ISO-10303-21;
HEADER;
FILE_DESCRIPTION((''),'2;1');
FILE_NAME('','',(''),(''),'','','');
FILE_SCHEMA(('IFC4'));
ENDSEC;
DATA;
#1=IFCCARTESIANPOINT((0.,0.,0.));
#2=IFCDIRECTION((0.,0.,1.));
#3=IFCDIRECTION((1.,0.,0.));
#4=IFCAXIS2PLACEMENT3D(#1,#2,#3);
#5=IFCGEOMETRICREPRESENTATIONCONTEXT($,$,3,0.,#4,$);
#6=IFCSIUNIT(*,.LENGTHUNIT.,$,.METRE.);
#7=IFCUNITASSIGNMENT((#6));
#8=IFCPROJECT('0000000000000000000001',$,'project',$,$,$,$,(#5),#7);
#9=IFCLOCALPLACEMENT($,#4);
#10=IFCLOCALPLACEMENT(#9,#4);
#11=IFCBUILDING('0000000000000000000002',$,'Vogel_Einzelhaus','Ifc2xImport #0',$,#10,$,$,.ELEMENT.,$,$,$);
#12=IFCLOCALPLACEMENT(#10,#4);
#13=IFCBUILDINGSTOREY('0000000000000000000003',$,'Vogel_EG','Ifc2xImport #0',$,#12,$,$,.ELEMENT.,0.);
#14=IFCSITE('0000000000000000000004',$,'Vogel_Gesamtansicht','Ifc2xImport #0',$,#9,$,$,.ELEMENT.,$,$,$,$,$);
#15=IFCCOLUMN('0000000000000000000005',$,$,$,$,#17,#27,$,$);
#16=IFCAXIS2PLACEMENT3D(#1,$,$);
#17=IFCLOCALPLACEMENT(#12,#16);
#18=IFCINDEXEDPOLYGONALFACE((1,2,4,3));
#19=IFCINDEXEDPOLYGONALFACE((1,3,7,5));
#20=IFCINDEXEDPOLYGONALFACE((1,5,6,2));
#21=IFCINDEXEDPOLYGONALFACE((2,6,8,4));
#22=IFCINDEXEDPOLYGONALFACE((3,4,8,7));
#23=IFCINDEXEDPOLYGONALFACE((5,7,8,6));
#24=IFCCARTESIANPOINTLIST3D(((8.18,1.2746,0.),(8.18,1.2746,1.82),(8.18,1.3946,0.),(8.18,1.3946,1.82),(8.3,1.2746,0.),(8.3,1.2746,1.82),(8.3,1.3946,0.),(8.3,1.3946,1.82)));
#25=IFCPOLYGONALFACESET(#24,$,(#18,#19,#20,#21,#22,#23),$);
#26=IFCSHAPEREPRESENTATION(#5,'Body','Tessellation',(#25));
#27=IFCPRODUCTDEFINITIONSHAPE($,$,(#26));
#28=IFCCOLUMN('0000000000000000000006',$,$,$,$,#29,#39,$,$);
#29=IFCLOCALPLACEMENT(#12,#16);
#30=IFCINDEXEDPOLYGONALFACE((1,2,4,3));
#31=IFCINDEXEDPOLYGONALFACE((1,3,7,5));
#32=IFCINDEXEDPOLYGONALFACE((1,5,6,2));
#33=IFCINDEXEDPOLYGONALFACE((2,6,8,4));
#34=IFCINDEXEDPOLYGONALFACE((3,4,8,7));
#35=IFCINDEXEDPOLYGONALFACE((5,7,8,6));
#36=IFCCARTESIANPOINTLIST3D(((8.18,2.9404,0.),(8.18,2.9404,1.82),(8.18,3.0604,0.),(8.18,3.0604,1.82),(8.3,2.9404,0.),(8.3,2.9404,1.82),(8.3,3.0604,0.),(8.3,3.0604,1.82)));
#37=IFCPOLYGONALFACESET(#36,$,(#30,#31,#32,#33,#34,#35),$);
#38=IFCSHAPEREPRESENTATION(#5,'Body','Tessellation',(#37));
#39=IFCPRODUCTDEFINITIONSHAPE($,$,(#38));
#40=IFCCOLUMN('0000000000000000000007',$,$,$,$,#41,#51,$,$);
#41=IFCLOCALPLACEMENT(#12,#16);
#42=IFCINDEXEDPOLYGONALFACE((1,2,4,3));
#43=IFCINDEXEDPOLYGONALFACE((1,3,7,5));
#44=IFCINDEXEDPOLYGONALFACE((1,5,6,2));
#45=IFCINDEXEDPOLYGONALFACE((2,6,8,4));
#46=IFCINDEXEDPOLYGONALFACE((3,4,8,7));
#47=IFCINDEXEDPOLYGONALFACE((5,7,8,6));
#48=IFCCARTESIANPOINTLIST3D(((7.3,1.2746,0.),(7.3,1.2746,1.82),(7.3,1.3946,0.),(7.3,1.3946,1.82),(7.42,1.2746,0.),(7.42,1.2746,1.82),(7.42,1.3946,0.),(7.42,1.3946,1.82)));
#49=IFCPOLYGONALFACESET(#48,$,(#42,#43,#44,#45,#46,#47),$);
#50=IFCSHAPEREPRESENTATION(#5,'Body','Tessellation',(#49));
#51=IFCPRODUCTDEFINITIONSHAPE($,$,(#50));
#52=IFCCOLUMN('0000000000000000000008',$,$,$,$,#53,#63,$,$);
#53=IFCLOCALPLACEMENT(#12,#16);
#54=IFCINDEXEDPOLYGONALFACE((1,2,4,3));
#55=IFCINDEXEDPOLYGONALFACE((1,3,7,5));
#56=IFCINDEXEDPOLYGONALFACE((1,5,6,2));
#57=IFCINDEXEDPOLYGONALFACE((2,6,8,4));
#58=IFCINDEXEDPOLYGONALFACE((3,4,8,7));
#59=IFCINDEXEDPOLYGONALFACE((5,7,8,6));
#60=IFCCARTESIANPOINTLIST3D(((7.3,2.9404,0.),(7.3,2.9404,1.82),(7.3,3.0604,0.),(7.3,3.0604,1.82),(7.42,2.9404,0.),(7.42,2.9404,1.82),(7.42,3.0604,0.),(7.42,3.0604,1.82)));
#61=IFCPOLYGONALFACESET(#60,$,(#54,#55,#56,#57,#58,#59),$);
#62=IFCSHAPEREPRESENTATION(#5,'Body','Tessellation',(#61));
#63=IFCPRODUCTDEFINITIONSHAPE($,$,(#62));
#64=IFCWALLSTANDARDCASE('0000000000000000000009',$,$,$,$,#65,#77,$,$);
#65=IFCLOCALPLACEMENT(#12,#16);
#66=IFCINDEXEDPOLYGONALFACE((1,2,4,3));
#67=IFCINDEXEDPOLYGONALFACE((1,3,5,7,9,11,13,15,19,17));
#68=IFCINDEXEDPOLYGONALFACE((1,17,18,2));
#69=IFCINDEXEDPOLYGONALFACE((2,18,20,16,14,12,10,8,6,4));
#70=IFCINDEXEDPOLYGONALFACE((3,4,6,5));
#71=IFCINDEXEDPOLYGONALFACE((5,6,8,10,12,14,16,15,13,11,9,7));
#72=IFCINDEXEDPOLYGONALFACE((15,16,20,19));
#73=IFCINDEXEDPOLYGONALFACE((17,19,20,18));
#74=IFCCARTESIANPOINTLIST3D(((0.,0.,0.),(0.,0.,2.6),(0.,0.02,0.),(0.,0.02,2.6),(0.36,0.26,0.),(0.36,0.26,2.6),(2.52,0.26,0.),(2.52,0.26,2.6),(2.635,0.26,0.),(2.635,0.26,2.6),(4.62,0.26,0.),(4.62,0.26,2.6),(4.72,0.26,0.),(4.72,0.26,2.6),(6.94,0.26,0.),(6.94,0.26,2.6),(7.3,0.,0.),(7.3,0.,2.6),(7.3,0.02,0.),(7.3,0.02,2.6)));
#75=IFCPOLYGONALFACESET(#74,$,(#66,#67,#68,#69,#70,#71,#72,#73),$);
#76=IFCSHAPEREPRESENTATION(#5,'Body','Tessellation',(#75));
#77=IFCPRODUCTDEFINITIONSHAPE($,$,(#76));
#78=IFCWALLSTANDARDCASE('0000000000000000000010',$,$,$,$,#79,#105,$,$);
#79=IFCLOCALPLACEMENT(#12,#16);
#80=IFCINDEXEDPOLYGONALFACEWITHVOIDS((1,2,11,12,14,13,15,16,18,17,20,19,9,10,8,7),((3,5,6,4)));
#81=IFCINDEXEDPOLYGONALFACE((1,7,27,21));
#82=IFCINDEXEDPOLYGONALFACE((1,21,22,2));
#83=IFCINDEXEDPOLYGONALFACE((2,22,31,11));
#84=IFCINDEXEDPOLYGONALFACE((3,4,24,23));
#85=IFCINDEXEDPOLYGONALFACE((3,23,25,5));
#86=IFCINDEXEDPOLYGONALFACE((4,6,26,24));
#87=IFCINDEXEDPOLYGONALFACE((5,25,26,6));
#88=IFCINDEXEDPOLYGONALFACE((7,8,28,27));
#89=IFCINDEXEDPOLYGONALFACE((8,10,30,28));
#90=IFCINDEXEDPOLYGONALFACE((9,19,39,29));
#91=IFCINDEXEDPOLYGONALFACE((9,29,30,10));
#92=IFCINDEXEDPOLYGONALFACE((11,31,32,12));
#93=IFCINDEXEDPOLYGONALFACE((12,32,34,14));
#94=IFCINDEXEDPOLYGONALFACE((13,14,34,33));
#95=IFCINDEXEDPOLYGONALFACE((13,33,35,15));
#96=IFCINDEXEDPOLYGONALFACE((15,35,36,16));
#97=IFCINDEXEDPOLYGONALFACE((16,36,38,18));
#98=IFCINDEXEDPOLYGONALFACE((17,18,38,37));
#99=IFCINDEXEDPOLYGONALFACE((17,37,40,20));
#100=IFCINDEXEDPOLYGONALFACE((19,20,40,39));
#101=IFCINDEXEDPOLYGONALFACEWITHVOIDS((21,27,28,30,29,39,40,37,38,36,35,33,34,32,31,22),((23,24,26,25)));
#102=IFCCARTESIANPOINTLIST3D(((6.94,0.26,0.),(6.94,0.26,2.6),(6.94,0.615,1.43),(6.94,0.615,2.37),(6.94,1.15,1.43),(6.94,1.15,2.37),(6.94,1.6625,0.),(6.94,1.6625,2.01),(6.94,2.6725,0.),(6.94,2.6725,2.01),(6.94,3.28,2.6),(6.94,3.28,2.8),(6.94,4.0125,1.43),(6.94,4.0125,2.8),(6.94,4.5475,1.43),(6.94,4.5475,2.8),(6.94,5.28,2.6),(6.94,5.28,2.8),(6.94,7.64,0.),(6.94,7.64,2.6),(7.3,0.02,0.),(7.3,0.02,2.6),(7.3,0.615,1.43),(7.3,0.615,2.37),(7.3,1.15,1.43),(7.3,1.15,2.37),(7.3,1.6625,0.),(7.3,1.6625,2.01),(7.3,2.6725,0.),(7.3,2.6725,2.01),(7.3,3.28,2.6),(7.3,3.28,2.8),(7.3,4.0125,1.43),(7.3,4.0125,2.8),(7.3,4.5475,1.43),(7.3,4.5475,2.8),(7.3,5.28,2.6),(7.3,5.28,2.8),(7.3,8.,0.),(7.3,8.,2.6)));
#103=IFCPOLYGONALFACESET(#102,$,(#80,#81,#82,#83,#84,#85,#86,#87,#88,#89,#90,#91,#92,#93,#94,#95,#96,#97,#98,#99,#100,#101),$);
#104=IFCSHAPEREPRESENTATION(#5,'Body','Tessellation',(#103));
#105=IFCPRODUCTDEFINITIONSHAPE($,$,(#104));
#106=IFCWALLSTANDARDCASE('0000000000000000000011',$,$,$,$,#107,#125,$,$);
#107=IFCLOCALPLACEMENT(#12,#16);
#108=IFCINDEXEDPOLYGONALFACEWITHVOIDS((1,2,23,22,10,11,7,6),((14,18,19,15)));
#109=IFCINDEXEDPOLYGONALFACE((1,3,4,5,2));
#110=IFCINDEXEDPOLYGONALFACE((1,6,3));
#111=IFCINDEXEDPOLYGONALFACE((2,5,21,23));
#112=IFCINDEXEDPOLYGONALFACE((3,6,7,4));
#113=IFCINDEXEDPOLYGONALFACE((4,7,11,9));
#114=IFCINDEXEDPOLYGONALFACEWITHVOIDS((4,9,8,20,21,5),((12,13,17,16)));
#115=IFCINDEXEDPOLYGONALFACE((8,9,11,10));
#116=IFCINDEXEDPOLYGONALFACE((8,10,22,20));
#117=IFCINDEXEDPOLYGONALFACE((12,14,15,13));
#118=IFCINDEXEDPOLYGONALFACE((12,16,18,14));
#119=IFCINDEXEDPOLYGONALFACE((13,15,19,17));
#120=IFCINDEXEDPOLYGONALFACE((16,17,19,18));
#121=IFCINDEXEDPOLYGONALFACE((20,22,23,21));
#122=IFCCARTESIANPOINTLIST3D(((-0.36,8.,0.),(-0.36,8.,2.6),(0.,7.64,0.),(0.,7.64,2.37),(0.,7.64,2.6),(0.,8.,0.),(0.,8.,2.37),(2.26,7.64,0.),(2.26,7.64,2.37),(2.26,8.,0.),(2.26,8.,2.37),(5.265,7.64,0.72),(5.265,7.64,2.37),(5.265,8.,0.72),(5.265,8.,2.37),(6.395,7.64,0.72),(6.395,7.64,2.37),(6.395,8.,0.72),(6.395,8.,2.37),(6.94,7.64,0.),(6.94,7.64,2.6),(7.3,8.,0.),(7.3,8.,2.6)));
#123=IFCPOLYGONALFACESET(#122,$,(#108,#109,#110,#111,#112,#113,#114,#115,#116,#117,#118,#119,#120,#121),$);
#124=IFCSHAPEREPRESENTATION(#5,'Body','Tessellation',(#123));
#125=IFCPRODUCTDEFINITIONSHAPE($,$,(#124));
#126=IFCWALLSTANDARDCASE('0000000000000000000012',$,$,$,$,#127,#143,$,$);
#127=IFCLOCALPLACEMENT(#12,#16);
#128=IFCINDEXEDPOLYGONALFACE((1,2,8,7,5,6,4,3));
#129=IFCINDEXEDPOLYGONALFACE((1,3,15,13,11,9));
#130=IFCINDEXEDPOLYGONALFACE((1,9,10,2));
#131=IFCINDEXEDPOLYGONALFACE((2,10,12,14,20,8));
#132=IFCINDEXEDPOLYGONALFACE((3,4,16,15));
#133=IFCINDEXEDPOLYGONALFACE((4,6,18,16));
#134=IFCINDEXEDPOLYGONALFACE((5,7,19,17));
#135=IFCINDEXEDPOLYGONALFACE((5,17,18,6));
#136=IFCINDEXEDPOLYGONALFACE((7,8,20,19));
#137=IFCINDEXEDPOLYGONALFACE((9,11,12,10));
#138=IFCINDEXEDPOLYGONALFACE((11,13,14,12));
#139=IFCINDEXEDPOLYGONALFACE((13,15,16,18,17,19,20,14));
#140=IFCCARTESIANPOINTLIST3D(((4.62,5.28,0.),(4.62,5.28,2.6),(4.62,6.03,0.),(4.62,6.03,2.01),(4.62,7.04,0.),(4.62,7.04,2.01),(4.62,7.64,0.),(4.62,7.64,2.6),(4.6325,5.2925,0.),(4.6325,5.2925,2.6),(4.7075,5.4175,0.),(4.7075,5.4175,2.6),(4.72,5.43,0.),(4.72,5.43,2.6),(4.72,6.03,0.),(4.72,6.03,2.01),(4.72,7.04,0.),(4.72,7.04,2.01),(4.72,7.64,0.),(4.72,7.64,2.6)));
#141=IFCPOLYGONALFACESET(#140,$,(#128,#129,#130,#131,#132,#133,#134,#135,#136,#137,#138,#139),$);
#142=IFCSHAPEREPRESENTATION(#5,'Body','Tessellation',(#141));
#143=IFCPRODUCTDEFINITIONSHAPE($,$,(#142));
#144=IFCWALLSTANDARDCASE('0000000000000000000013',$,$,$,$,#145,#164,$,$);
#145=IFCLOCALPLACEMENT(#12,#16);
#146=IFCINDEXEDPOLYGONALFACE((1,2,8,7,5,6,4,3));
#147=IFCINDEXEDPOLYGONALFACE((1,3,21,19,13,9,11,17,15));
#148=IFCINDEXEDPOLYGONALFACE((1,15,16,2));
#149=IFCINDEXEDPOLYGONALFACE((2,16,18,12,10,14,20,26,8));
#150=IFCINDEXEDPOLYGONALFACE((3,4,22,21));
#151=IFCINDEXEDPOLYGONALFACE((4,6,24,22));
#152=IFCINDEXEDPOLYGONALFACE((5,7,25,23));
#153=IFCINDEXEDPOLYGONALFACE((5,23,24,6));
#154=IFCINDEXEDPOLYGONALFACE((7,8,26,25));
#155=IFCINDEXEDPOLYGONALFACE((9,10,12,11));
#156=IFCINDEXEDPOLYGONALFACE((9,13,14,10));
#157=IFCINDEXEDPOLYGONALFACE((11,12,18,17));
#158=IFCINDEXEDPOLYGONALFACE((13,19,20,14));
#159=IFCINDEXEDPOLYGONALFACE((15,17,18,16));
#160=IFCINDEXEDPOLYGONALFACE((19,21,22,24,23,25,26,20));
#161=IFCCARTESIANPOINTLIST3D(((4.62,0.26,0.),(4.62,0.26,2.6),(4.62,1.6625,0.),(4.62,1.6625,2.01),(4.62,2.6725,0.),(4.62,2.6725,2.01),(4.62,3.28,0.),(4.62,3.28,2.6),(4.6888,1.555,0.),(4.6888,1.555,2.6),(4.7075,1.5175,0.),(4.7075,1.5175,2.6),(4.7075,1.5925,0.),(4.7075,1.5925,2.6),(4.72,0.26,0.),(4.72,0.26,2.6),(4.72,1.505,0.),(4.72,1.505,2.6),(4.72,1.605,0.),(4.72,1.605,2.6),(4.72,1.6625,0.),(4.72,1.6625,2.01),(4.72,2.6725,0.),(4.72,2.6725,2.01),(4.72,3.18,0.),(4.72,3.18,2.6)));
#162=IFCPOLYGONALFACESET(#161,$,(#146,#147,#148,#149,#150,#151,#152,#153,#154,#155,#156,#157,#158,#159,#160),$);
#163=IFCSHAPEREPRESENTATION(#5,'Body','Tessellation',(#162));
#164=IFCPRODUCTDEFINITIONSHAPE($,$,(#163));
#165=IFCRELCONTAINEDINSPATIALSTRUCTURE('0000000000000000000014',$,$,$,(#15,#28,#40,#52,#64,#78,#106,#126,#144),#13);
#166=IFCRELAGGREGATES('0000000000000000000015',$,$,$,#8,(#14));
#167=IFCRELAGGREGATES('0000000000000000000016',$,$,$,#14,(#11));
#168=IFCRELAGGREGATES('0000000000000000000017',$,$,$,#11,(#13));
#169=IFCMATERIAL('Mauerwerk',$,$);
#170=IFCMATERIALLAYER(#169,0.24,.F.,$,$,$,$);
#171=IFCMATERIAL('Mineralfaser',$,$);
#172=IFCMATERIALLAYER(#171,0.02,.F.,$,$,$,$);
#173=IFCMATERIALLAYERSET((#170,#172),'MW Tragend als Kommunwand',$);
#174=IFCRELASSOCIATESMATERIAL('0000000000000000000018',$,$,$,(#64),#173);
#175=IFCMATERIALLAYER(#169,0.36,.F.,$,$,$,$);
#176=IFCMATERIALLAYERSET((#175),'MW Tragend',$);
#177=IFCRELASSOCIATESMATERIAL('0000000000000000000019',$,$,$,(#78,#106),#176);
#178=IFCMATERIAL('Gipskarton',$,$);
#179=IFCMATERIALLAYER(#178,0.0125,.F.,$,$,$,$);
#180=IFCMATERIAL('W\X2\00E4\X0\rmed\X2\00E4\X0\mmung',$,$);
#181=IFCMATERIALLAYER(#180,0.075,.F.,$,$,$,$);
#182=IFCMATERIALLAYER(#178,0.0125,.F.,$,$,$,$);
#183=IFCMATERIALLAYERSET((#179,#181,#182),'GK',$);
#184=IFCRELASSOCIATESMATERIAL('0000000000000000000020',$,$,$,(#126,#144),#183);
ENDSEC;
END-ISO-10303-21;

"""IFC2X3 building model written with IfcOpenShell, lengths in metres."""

from ifc_helpers import new_model, si_unit, frame, origin_with_axes, origin_2d_with_axis, place, context, project, spatial, polyline, rectangle, outline, extrude, clip, bounded_halfspace, shape, material, layer, layer_set, layer_usage, element, save


model = new_model("IFC2X3")

# Units and contexts
context_of_model = context(None, 3, precision=0.0, world=origin_with_axes())
ifc_project = project(units=[si_unit("LENGTHUNIT", "METRE")], contexts=[context_of_model])

# Site, building, storey
site_placement = place(None, origin_with_axes())
site = spatial("IfcSite", under=ifc_project, at=site_placement, Name="Vogel_Gesamtansicht", Description="Ifc2xImport #0", CompositionType="ELEMENT")
building_placement = place(site_placement, origin_with_axes())
building = spatial("IfcBuilding", under=site, at=building_placement, Name="Vogel_Einzelhaus", Description="Ifc2xImport #0", CompositionType="ELEMENT")
storey_placement = place(building_placement, origin_with_axes())
storey = spatial("IfcBuildingStorey", under=building, at=storey_placement, Name="Vogel_EG", Description="Ifc2xImport #0", CompositionType="ELEMENT", Elevation=0.0)

# Columns
for number, where, z_axis, x_axis in (
    (1, (8.24, 1.3346, 0.0), (0.0, 1.0, 0.0), (0.0, 0.0, 1.0)),
    (2, (8.24, 3.0004, 0.0), (0.0, 1.0, 0.0), (0.0, 0.0, 1.0)),
    (3, (7.36, 1.3346, 0.0), (0.0, 1.0, 0.0), (0.0, 0.0, 1.0)),
    (4, (7.36, 3.0004, 0.0), (0.0, 1.0, 0.0), (0.0, 0.0, 1.0)),
):
    element("IfcColumn", number, at=place(storey_placement, frame(where, z_axis=z_axis, x_axis=x_axis)), inside=storey, context=context_of_model, shape_type="SweptSolid", body=[
        extrude(outline(polyline([(-0.06, -0.06), (0.06, -0.06), (0.06, 0.06), (-0.06, 0.06), (-0.06, -0.06)])), frame((0.0, 0.0, 0.0), z_axis=(1.0, 0.0, 0.0), x_axis=(0.0, 1.0, 0.0)), (0.0, 0.0, 1.0), 1.82),
    ])

# Wall
ifc_material_1 = material(Name="Mauerwerk")
ifc_layer_1 = layer(ifc_material_1, 0.24, ventilated=False)
ifc_material_2 = material(Name="Mineralfaser")
ifc_layer_2 = layer(ifc_material_2, 0.02, ventilated=False)
ifc_layer_set_1 = layer_set([ifc_layer_1, ifc_layer_2], Name="MW Tragend als Kommunwand")
ifc_layer_usage_1 = layer_usage(ifc_layer_set_1, "AXIS2", "POSITIVE", -0.26)
wall_1_placement = place(storey_placement, frame((7.3, 0.0, 0.0), z_axis=(0.0, 0.0, 1.0), x_axis=(-1.0, 0.0, 0.0)))
element("IfcWallStandardCase", 5, at=wall_1_placement, inside=storey, material=ifc_layer_usage_1, context=context_of_model, shape_type="SweptSolid", body=[
    extrude(outline(polyline([(0.0, -0.02), (0.36, -0.26), (2.58, -0.26), (2.68, -0.26), (4.665, -0.26), (4.78, -0.26), (6.94, -0.26), (7.3, -0.02), (7.3, 0.0), (0.0, 0.0), (0.0, -0.02)])), origin_with_axes(), (0.0, 0.0, 1.0), 2.6),
])

# Walls, openings
ifc_layer_3 = layer(ifc_material_1, 0.36, ventilated=False)
ifc_layer_set_2 = layer_set([ifc_layer_3], Name="MW Tragend")
ifc_layer_usage_2 = layer_usage(ifc_layer_set_2, "AXIS2", "POSITIVE", -0.36)
wall_2_placement = place(storey_placement, frame((7.3, 7.64, 0.0), z_axis=(0.0, 0.0, 1.0), x_axis=(0.0, -1.0, 0.0)))
wall_2 = element("IfcWallStandardCase", 6, at=wall_2_placement, inside=storey, material=ifc_layer_usage_2, context=context_of_model, shape_type="Clipping", body=[
    clip(clip(clip(extrude(outline(polyline([(4.41, -0.36), (4.46, -0.36), (6.035, -0.36), (6.085, -0.36), (6.135, -0.36), (7.38, -0.36), (7.62, 0.0), (6.085, 0.0), (4.41, 0.0), (2.285, 0.0), (-0.36, 0.0), (0.0, -0.36), (2.21, -0.36), (2.285, -0.36), (2.36, -0.36), (4.36, -0.36), (4.41, -0.36)])), origin_with_axes(), (0.0, 0.0, 1.0), 2.8), bounded_halfspace(frame((0.0, 0.0, 2.6), z_axis=(0.0, 0.0, -1.0), x_axis=(1.0, 0.0, 0.0)), True, origin_with_axes(), polyline([(-7.62, -0.36), (2.36, -0.36), (2.36, 0.36), (-7.62, 0.36), (-7.62, -0.36)]))), bounded_halfspace(frame((2.36, 0.0, 2.8), z_axis=(0.0, 0.0, -1.0), x_axis=(1.0, 0.0, 0.0)), True, origin_with_axes(), polyline([(2.36, -0.36), (4.36, -0.36), (4.36, 0.36), (2.36, 0.36), (2.36, -0.36)]))), bounded_halfspace(frame((4.36, 0.0, 2.6), z_axis=(0.0, 0.0, -1.0), x_axis=(1.0, 0.0, 0.0)), True, origin_with_axes(), polyline([(4.36, -0.36), (15.24, -0.36), (15.24, 0.36), (4.36, 0.36), (4.36, -0.36)]))),
])
opening_1_placement = place(wall_2_placement, frame((5.9775, -0.36, 0.0), z_axis=(-1.0, 0.0, 0.0), x_axis=(0.0, 0.0, 1.0)))
element("IfcOpeningElement", 7, at=opening_1_placement, cuts=wall_2, shapes=[
    shape(context_of_model, None, "SweptSolid", [extrude(rectangle(XDim=2.01, YDim=1.01, at=origin_2d_with_axis()), frame((1.005, 0.0, 0.505), z_axis=(0.0, 1.0, 0.0), x_axis=(1.0, 0.0, 0.0)), (0.0, 0.0, 1.0), 0.36)]),
])
opening_2_placement = place(wall_2_placement, frame((6.49, 0.0, 1.43), z_axis=(1.0, 0.0, 0.0), x_axis=(0.0, 0.0, 1.0)))
element("IfcOpeningElement", 8, at=opening_2_placement, cuts=wall_2, shapes=[
    shape(context_of_model, None, "SweptSolid", [extrude(rectangle(XDim=0.94, YDim=0.535, at=origin_2d_with_axis()), frame((0.47, 0.0, 0.2675), z_axis=(0.0, 1.0, 0.0), x_axis=(1.0, 0.0, 0.0)), (0.0, 0.0, 1.0), 0.36)]),
])
opening_3_placement = place(wall_2_placement, frame((3.6275, -0.36, 1.43), z_axis=(-1.0, 0.0, 0.0), x_axis=(0.0, 0.0, 1.0)))
element("IfcOpeningElement", 9, at=opening_3_placement, cuts=wall_2, shapes=[
    shape(context_of_model, None, "SweptSolid", [extrude(rectangle(XDim=1.65, YDim=0.535, at=origin_2d_with_axis()), frame((0.825, 0.0, 0.2675), z_axis=(0.0, 1.0, 0.0), x_axis=(1.0, 0.0, 0.0)), (0.0, 0.0, 1.0), 0.36)]),
])
wall_3_placement = place(storey_placement, frame((0.0, 8.0, 0.0), z_axis=(0.0, 0.0, 1.0), x_axis=(1.0, 0.0, 0.0)))
wall_3 = element("IfcWallStandardCase", 10, at=wall_3_placement, inside=storey, material=ifc_layer_usage_2, context=context_of_model, shape_type="SweptSolid", body=[
    extrude(outline(polyline([(-0.36, 0.0), (0.0, -0.36), (4.62, -0.36), (4.67, -0.36), (4.72, -0.36), (6.94, -0.36), (7.3, 0.0), (4.67, 0.0), (-0.36, 0.0)])), origin_with_axes(), (0.0, 0.0, 1.0), 2.6),
])
opening_4_placement = place(wall_3_placement, frame((0.0, 0.0, 0.0), z_axis=(1.0, 0.0, 0.0), x_axis=(0.0, 0.0, 1.0)))
element("IfcOpeningElement", 11, at=opening_4_placement, cuts=wall_3, shapes=[
    shape(context_of_model, None, "SweptSolid", [extrude(rectangle(XDim=2.37, YDim=2.26, at=origin_2d_with_axis()), frame((1.185, 0.0, 1.13), z_axis=(0.0, 1.0, 0.0), x_axis=(1.0, 0.0, 0.0)), (0.0, 0.0, 1.0), 0.36)]),
])
opening_5_placement = place(wall_3_placement, frame((6.395, -0.36, 0.72), z_axis=(-1.0, 0.0, 0.0), x_axis=(0.0, 0.0, 1.0)))
element("IfcOpeningElement", 12, at=opening_5_placement, cuts=wall_3, shapes=[
    shape(context_of_model, None, "SweptSolid", [extrude(rectangle(XDim=1.65, YDim=1.13, at=origin_2d_with_axis()), frame((0.825, 0.0, 0.565), z_axis=(0.0, 1.0, 0.0), x_axis=(1.0, 0.0, 0.0)), (0.0, 0.0, 1.0), 0.36)]),
])

# Shared definitions
ifc_material_3 = material(Name="Gipskarton")
ifc_layer_4 = layer(ifc_material_3, 0.0125, ventilated=False)
ifc_material_4 = material(Name="Wärmedämmung")
ifc_layer_5 = layer(ifc_material_4, 0.075, ventilated=False)
ifc_layer_6 = layer(ifc_material_3, 0.0125, ventilated=False)
ifc_layer_set_3 = layer_set([ifc_layer_4, ifc_layer_5, ifc_layer_6], Name="GK")
ifc_layer_usage_3 = layer_usage(ifc_layer_set_3, "AXIS2", "POSITIVE", -0.1)

# Wall, opening
wall_4_placement = place(storey_placement, frame((4.62, 5.28, 0.0), z_axis=(0.0, 0.0, 1.0), x_axis=(0.0, 1.0, 0.0)))
wall_4 = element("IfcWallStandardCase", 13, at=wall_4_placement, inside=storey, material=ifc_layer_usage_3, context=context_of_model, shape_type="SweptSolid", body=[
    extrude(outline(polyline([(0.1375, -0.0875), (0.15, -0.1), (2.36, -0.1), (2.36, 0.0), (0.0, 0.0), (0.0125, -0.0125), (0.1375, -0.0875)])), origin_with_axes(), (0.0, 0.0, 1.0), 2.6),
])
opening_6_placement = place(wall_4_placement, frame((1.76, -0.1, 0.0), z_axis=(-1.0, 0.0, 0.0), x_axis=(0.0, 0.0, 1.0)))
element("IfcOpeningElement", 14, at=opening_6_placement, cuts=wall_4, shapes=[
    shape(context_of_model, None, "SweptSolid", [extrude(rectangle(XDim=2.01, YDim=1.01, at=origin_2d_with_axis()), frame((1.005, 0.0, 0.505), z_axis=(0.0, 1.0, 0.0), x_axis=(1.0, 0.0, 0.0)), (0.0, 0.0, 1.0), 0.1)]),
])

# Wall, opening
wall_5_placement = place(storey_placement, frame((4.62, 0.26, 0.0), z_axis=(0.0, 0.0, 1.0), x_axis=(0.0, 1.0, 0.0)))
wall_5 = element("IfcWallStandardCase", 15, at=wall_5_placement, inside=storey, material=ifc_layer_usage_3, context=context_of_model, shape_type="SweptSolid", body=[
    extrude(outline(polyline([(1.245, -0.1), (1.2575, -0.0875), (1.295, -0.0688), (1.3325, -0.0875), (1.345, -0.1), (2.92, -0.1), (3.02, 0.0), (0.0, 0.0), (0.0, -0.1), (1.245, -0.1)])), origin_with_axes(), (0.0, 0.0, 1.0), 2.6),
])
opening_7_placement = place(wall_5_placement, frame((2.4125, -0.1, 0.0), z_axis=(-1.0, 0.0, 0.0), x_axis=(0.0, 0.0, 1.0)))
element("IfcOpeningElement", 16, at=opening_7_placement, cuts=wall_5, shapes=[
    shape(context_of_model, None, "SweptSolid", [extrude(rectangle(XDim=2.01, YDim=1.01, at=origin_2d_with_axis()), frame((1.005, 0.0, 0.505), z_axis=(0.0, 1.0, 0.0), x_axis=(1.0, 0.0, 0.0)), (0.0, 0.0, 1.0), 0.1)]),
])

save(model, "model.ifc")
